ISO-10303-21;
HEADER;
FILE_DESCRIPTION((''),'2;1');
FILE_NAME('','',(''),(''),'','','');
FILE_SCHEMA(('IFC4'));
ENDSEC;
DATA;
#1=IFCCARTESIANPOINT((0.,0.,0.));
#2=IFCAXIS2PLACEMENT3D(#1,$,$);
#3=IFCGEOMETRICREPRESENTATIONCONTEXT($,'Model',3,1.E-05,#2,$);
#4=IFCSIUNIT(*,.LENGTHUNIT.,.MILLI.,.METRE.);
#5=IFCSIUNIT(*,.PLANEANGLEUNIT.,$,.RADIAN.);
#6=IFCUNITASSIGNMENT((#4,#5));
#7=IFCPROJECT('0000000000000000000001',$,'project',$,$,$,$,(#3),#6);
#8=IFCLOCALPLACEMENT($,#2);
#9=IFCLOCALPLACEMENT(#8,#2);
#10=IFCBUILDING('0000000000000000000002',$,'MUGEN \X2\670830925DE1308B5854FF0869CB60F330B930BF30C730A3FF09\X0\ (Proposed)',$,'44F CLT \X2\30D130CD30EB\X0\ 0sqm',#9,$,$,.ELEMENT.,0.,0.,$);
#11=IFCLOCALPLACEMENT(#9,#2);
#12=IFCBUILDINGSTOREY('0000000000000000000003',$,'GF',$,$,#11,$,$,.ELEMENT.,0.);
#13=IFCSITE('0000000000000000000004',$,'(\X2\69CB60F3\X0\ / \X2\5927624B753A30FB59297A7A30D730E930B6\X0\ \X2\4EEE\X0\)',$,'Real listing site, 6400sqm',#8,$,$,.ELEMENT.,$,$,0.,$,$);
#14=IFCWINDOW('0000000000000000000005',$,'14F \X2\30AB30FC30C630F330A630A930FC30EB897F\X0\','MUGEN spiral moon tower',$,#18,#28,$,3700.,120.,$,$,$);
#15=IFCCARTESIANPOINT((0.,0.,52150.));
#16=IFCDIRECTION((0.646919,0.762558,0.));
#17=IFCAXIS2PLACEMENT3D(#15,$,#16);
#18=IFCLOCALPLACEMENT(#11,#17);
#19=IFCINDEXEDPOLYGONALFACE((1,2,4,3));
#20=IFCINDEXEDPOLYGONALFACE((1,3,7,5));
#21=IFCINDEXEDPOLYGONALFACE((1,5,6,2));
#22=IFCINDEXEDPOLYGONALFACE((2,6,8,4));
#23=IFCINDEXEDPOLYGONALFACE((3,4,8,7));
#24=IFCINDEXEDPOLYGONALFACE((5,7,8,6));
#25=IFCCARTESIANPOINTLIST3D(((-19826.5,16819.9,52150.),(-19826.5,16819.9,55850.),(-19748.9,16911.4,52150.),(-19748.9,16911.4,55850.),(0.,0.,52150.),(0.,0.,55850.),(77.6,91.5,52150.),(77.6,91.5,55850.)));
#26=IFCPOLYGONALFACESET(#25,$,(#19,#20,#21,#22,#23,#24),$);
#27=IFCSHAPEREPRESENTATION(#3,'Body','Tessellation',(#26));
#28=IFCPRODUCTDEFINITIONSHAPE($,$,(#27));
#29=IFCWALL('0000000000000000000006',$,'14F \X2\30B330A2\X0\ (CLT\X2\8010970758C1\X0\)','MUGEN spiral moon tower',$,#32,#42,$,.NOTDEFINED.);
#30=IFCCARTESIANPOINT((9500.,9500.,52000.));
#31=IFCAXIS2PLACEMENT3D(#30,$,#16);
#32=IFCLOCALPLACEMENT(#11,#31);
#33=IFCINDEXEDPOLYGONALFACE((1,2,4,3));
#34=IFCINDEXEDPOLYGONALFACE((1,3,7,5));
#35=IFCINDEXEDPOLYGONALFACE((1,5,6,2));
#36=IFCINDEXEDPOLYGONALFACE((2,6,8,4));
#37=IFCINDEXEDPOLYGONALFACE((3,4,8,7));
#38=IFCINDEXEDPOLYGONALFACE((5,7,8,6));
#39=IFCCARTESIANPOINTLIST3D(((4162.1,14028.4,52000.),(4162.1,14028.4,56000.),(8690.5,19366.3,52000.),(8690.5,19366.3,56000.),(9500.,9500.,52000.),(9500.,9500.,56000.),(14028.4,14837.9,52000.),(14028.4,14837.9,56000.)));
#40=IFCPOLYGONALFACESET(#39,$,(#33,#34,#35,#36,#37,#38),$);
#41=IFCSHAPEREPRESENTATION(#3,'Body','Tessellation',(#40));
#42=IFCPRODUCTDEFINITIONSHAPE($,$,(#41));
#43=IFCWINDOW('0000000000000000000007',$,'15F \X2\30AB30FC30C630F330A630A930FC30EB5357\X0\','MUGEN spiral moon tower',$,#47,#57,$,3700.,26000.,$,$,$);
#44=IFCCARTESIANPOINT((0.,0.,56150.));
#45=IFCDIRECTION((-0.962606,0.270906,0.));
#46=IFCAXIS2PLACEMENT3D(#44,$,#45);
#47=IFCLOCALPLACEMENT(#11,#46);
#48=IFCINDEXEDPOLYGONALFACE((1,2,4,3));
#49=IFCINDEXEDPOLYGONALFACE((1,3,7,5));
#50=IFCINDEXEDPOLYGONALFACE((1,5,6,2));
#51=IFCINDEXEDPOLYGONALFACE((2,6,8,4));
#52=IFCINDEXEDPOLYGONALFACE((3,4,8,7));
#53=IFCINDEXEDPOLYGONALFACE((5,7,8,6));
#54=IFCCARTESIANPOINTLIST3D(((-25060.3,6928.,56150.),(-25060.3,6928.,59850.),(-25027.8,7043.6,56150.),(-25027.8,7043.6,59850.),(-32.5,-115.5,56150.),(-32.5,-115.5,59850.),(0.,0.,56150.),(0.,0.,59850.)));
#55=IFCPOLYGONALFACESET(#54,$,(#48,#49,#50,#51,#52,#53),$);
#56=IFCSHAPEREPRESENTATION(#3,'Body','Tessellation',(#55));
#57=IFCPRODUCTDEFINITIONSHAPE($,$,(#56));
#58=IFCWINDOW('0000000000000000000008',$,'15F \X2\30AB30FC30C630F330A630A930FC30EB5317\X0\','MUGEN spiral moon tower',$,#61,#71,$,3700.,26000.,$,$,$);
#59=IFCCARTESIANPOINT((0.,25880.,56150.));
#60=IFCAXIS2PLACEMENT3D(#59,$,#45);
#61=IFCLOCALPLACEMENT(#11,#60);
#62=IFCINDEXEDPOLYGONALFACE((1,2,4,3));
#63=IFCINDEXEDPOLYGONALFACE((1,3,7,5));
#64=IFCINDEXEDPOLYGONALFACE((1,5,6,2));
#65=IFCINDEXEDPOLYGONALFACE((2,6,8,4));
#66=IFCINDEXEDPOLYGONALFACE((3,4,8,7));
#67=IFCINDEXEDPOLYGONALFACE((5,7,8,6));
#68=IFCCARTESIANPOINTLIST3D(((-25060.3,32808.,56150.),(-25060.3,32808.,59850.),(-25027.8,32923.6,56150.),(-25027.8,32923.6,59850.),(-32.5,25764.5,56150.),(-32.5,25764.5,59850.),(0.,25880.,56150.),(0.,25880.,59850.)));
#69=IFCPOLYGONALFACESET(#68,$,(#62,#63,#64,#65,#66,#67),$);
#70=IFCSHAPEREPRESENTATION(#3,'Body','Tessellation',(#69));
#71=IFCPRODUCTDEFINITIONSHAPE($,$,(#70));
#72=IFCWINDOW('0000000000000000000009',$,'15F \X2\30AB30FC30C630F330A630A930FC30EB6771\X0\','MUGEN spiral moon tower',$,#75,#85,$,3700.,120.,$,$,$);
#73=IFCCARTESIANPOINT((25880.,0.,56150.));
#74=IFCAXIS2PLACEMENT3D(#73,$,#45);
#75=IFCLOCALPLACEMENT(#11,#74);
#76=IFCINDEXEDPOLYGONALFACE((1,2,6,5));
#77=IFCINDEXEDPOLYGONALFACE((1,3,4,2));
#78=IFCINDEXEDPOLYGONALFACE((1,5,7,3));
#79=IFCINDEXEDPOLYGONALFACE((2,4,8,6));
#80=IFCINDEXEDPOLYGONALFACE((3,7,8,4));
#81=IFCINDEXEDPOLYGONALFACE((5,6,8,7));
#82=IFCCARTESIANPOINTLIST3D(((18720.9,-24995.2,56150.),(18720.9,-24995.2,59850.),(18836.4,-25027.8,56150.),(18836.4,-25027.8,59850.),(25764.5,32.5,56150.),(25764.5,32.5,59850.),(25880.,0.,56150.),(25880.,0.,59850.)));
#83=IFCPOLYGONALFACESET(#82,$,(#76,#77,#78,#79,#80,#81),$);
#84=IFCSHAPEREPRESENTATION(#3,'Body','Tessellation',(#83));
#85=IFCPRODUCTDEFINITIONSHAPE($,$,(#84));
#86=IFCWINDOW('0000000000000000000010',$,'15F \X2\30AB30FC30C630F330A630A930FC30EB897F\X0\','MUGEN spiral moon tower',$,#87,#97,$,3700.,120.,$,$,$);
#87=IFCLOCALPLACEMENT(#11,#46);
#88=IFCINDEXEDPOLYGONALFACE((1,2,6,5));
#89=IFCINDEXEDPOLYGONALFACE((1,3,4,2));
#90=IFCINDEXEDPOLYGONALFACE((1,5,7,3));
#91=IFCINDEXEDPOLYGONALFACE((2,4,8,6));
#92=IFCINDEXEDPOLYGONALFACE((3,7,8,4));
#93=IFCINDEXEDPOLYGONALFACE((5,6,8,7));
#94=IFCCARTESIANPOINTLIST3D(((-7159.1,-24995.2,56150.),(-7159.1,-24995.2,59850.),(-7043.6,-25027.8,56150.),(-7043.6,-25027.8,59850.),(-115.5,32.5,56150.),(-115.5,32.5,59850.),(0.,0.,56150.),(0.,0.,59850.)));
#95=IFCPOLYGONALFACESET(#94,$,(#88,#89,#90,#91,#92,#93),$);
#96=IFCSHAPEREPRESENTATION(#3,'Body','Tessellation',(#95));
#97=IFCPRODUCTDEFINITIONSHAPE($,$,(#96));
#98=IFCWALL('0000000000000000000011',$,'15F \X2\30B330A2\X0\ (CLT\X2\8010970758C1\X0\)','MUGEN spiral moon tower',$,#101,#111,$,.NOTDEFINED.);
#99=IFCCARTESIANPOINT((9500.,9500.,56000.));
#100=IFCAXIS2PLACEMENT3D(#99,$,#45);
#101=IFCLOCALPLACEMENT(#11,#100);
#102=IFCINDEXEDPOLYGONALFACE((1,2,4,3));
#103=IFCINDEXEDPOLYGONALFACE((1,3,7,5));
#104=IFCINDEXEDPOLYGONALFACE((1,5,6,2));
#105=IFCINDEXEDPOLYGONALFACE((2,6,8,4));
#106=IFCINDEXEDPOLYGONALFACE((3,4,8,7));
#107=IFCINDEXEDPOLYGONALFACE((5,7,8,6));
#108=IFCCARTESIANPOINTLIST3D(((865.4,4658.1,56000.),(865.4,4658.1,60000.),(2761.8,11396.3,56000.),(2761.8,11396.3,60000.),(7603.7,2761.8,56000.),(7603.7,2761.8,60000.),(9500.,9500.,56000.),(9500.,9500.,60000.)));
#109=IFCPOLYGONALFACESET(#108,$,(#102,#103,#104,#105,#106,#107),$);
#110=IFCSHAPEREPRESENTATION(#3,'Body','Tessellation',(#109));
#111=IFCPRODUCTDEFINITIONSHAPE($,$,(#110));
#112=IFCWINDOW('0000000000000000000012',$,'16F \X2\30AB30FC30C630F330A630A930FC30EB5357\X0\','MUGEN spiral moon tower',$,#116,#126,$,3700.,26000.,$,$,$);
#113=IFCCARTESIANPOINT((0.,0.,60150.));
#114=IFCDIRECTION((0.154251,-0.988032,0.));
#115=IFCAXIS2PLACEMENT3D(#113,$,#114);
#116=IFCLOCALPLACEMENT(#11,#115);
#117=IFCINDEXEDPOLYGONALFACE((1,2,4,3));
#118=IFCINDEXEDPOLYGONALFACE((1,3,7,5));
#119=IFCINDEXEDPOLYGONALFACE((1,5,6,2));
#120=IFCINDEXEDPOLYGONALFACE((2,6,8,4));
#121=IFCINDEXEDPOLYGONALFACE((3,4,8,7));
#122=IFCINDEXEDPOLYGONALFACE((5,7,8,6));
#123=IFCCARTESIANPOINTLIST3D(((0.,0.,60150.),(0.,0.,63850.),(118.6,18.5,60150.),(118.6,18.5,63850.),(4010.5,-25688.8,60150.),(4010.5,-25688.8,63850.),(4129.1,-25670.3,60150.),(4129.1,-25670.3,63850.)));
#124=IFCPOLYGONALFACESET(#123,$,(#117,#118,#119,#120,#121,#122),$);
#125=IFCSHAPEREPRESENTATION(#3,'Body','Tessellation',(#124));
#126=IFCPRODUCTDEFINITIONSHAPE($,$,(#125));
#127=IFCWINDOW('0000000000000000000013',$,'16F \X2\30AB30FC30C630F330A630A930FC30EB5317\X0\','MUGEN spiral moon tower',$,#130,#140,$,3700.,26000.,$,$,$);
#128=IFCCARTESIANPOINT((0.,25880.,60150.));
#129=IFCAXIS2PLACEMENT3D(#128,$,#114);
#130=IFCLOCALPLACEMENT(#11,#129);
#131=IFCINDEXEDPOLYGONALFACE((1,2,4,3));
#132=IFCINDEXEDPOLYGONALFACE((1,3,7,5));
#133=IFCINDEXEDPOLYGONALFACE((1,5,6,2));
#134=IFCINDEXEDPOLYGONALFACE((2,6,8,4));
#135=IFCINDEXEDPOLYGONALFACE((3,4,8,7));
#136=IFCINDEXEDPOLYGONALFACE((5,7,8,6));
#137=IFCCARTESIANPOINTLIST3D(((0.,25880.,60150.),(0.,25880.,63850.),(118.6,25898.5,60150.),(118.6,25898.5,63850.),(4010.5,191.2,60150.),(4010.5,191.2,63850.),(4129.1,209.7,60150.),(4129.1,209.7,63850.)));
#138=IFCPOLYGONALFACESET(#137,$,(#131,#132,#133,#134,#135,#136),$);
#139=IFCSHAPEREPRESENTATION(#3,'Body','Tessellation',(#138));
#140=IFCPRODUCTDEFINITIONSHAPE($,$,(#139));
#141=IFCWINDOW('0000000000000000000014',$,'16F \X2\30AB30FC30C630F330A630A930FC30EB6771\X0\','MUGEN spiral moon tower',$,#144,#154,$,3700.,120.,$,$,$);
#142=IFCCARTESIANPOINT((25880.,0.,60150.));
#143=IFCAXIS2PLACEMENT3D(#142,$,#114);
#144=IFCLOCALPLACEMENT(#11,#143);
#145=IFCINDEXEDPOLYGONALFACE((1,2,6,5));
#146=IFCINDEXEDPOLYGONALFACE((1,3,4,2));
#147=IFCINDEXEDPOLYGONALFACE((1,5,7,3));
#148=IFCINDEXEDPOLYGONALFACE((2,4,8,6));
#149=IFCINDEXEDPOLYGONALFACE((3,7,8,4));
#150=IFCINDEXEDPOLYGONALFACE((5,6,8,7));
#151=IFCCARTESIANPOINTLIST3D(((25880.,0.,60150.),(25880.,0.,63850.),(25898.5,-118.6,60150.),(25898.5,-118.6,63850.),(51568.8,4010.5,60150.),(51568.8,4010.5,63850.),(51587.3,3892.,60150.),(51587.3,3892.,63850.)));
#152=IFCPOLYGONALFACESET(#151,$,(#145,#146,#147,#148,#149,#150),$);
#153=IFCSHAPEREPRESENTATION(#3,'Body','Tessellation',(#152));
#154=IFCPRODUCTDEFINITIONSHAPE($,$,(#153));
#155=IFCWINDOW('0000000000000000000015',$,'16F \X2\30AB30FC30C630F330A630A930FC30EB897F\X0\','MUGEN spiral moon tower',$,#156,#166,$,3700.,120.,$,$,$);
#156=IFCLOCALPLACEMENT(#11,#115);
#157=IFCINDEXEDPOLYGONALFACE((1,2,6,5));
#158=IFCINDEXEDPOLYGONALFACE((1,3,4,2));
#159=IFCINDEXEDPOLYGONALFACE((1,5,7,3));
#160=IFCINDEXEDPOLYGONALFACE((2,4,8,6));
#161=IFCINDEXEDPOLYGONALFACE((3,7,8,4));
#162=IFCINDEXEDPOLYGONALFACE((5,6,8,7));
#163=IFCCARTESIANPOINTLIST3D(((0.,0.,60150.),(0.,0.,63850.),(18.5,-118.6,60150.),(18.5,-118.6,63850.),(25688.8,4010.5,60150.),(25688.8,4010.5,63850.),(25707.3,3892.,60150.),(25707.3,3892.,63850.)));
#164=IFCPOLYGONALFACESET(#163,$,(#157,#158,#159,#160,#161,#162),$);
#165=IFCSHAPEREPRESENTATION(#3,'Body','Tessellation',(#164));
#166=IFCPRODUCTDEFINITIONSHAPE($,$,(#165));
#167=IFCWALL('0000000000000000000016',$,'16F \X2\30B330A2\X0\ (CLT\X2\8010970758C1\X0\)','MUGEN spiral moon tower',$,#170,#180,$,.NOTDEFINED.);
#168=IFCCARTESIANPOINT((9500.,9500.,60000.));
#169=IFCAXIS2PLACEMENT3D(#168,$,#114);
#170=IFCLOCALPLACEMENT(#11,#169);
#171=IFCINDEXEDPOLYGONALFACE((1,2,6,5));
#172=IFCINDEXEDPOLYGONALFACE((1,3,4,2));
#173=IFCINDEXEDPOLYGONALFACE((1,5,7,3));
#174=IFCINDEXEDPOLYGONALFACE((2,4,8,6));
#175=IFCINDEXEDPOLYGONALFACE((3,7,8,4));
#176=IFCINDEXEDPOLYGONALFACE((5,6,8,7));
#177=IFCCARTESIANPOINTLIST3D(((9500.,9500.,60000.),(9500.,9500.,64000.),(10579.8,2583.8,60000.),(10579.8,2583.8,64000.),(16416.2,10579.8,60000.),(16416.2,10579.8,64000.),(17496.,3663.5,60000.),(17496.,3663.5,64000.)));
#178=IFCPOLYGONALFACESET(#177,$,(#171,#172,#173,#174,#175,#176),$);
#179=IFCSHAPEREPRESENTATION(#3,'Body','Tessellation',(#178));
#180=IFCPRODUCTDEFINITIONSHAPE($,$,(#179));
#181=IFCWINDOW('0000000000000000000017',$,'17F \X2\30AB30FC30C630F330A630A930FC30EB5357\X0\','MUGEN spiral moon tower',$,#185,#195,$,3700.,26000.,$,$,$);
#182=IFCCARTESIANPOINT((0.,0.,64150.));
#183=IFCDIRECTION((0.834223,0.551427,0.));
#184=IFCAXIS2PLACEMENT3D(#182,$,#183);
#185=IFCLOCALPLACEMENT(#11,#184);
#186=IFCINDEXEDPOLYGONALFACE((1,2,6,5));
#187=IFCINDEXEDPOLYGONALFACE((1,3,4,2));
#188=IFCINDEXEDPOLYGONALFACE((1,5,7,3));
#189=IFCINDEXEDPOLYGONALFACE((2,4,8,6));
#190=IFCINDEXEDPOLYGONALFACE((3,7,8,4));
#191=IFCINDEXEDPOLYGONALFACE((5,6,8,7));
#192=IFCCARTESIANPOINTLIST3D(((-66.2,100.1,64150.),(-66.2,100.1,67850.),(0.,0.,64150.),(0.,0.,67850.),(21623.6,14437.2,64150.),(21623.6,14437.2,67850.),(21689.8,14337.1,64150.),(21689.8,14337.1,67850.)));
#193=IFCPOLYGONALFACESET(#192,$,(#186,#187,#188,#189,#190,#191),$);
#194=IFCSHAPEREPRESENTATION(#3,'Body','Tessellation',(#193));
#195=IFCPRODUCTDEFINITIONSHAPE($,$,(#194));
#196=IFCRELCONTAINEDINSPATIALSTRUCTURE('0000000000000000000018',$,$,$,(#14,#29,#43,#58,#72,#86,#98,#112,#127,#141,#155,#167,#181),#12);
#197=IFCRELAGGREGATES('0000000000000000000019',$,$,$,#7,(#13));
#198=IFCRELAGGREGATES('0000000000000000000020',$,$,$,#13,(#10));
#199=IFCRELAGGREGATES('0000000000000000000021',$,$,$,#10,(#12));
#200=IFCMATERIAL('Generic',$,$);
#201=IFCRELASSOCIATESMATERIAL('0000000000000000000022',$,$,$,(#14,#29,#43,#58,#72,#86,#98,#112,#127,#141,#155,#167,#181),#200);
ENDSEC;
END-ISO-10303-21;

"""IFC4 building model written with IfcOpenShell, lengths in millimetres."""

from ifc_helpers import new_model, si_unit, frame, frame_2d, origin, place, context, project, spatial, rectangle, extrude, material, element, save


model = new_model("IFC4")

# Units and contexts
model_context = context("Model", 3, precision=1e-05, world=origin())
ifc_project = project(units=[si_unit("LENGTHUNIT", "METRE", prefix="MILLI"), si_unit("PLANEANGLEUNIT", "RADIAN")], contexts=[model_context])

# Site, building, storey
site_placement = place(None, origin())
site = spatial("IfcSite", under=ifc_project, at=site_placement, Name="(構想 / 大手町・天空プラザ 仮)", ObjectType="Real listing site, 6400sqm", CompositionType="ELEMENT", RefElevation=0.0)
building_placement = place(site_placement, origin())
building = spatial("IfcBuilding", under=site, at=building_placement, Name="MUGEN 月を巡る塔（構想スタディ） (Proposed)", ObjectType="44F CLT パネル 0sqm", CompositionType="ELEMENT", ElevationOfRefHeight=0.0, ElevationOfTerrain=0.0)
storey_placement = place(building_placement, origin())
storey = spatial("IfcBuildingStorey", under=building, at=storey_placement, Name="GF", CompositionType="ELEMENT", Elevation=0.0)

# Shared definitions
ifc_material = material(Name="Generic")

# Window
window_1_placement = place(storey_placement, frame((0.0, 0.0, 52150.0), x_axis=(0.646919, 0.762558, 0.0)))
element("IfcWindow", 1, at=window_1_placement, inside=storey, material=ifc_material, Name="14F カーテンウォール西", Description="MUGEN spiral moon tower", OverallHeight=3700.0, OverallWidth=120.0, context=model_context, shape_type="SweptSolid", body=[
    extrude(rectangle(XDim=120.0, YDim=26000.0, at=frame_2d((60.0, 13000.0))), frame((0.0, 0.0, 52150.0), x_axis=(0.646919, 0.762558, 0.0)), (0.0, 0.0, 1.0), 3700.0),
])

# Wall
wall_1_placement = place(storey_placement, frame((9500.0, 9500.0, 52000.0), x_axis=(0.646919, 0.762558, 0.0)))
element("IfcWall", 2, at=wall_1_placement, inside=storey, material=ifc_material, Name="14F コア (CLT耐震壁)", Description="MUGEN spiral moon tower", PredefinedType="NOTDEFINED", context=model_context, shape_type="SweptSolid", body=[
    extrude(rectangle(XDim=7000.0, YDim=7000.0, at=frame_2d((3500.0, 3500.0))), frame((9500.0, 9500.0, 52000.0), x_axis=(0.646919, 0.762558, 0.0)), (0.0, 0.0, 1.0), 4000.0),
])

# Windows
window_2_placement = place(storey_placement, frame((0.0, 0.0, 56150.0), x_axis=(-0.962606, 0.270906, 0.0)))
element("IfcWindow", 3, at=window_2_placement, inside=storey, material=ifc_material, Name="15F カーテンウォール南", Description="MUGEN spiral moon tower", OverallHeight=3700.0, OverallWidth=26000.0, context=model_context, shape_type="SweptSolid", body=[
    extrude(rectangle(XDim=26000.0, YDim=120.0, at=frame_2d((13000.0, 60.0))), frame((0.0, 0.0, 56150.0), x_axis=(-0.962606, 0.270906, 0.0)), (0.0, 0.0, 1.0), 3700.0),
])
window_3_placement = place(storey_placement, frame((0.0, 25880.0, 56150.0), x_axis=(-0.962606, 0.270906, 0.0)))
element("IfcWindow", 4, at=window_3_placement, inside=storey, material=ifc_material, Name="15F カーテンウォール北", Description="MUGEN spiral moon tower", OverallHeight=3700.0, OverallWidth=26000.0, context=model_context, shape_type="SweptSolid", body=[
    extrude(rectangle(XDim=26000.0, YDim=120.0, at=frame_2d((13000.0, 60.0))), frame((0.0, 25880.0, 56150.0), x_axis=(-0.962606, 0.270906, 0.0)), (0.0, 0.0, 1.0), 3700.0),
])
window_4_placement = place(storey_placement, frame((25880.0, 0.0, 56150.0), x_axis=(-0.962606, 0.270906, 0.0)))
element("IfcWindow", 5, at=window_4_placement, inside=storey, material=ifc_material, Name="15F カーテンウォール東", Description="MUGEN spiral moon tower", OverallHeight=3700.0, OverallWidth=120.0, context=model_context, shape_type="SweptSolid", body=[
    extrude(rectangle(XDim=120.0, YDim=26000.0, at=frame_2d((60.0, 13000.0))), frame((25880.0, 0.0, 56150.0), x_axis=(-0.962606, 0.270906, 0.0)), (0.0, 0.0, 1.0), 3700.0),
])
window_5_placement = place(storey_placement, frame((0.0, 0.0, 56150.0), x_axis=(-0.962606, 0.270906, 0.0)))
element("IfcWindow", 6, at=window_5_placement, inside=storey, material=ifc_material, Name="15F カーテンウォール西", Description="MUGEN spiral moon tower", OverallHeight=3700.0, OverallWidth=120.0, context=model_context, shape_type="SweptSolid", body=[
    extrude(rectangle(XDim=120.0, YDim=26000.0, at=frame_2d((60.0, 13000.0))), frame((0.0, 0.0, 56150.0), x_axis=(-0.962606, 0.270906, 0.0)), (0.0, 0.0, 1.0), 3700.0),
])

# Wall
wall_2_placement = place(storey_placement, frame((9500.0, 9500.0, 56000.0), x_axis=(-0.962606, 0.270906, 0.0)))
element("IfcWall", 7, at=wall_2_placement, inside=storey, material=ifc_material, Name="15F コア (CLT耐震壁)", Description="MUGEN spiral moon tower", PredefinedType="NOTDEFINED", context=model_context, shape_type="SweptSolid", body=[
    extrude(rectangle(XDim=7000.0, YDim=7000.0, at=frame_2d((3500.0, 3500.0))), frame((9500.0, 9500.0, 56000.0), x_axis=(-0.962606, 0.270906, 0.0)), (0.0, 0.0, 1.0), 4000.0),
])

# Windows
window_6_placement = place(storey_placement, frame((0.0, 0.0, 60150.0), x_axis=(0.154251, -0.988032, 0.0)))
element("IfcWindow", 8, at=window_6_placement, inside=storey, material=ifc_material, Name="16F カーテンウォール南", Description="MUGEN spiral moon tower", OverallHeight=3700.0, OverallWidth=26000.0, context=model_context, shape_type="SweptSolid", body=[
    extrude(rectangle(XDim=26000.0, YDim=120.0, at=frame_2d((13000.0, 60.0))), frame((0.0, 0.0, 60150.0), x_axis=(0.154251, -0.988032, 0.0)), (0.0, 0.0, 1.0), 3700.0),
])
window_7_placement = place(storey_placement, frame((0.0, 25880.0, 60150.0), x_axis=(0.154251, -0.988032, 0.0)))
element("IfcWindow", 9, at=window_7_placement, inside=storey, material=ifc_material, Name="16F カーテンウォール北", Description="MUGEN spiral moon tower", OverallHeight=3700.0, OverallWidth=26000.0, context=model_context, shape_type="SweptSolid", body=[
    extrude(rectangle(XDim=26000.0, YDim=120.0, at=frame_2d((13000.0, 60.0))), frame((0.0, 25880.0, 60150.0), x_axis=(0.154251, -0.988032, 0.0)), (0.0, 0.0, 1.0), 3700.0),
])
window_8_placement = place(storey_placement, frame((25880.0, 0.0, 60150.0), x_axis=(0.154251, -0.988032, 0.0)))
element("IfcWindow", 10, at=window_8_placement, inside=storey, material=ifc_material, Name="16F カーテンウォール東", Description="MUGEN spiral moon tower", OverallHeight=3700.0, OverallWidth=120.0, context=model_context, shape_type="SweptSolid", body=[
    extrude(rectangle(XDim=120.0, YDim=26000.0, at=frame_2d((60.0, 13000.0))), frame((25880.0, 0.0, 60150.0), x_axis=(0.154251, -0.988032, 0.0)), (0.0, 0.0, 1.0), 3700.0),
])
window_9_placement = place(storey_placement, frame((0.0, 0.0, 60150.0), x_axis=(0.154251, -0.988032, 0.0)))
element("IfcWindow", 11, at=window_9_placement, inside=storey, material=ifc_material, Name="16F カーテンウォール西", Description="MUGEN spiral moon tower", OverallHeight=3700.0, OverallWidth=120.0, context=model_context, shape_type="SweptSolid", body=[
    extrude(rectangle(XDim=120.0, YDim=26000.0, at=frame_2d((60.0, 13000.0))), frame((0.0, 0.0, 60150.0), x_axis=(0.154251, -0.988032, 0.0)), (0.0, 0.0, 1.0), 3700.0),
])

# Wall
wall_3_placement = place(storey_placement, frame((9500.0, 9500.0, 60000.0), x_axis=(0.154251, -0.988032, 0.0)))
element("IfcWall", 12, at=wall_3_placement, inside=storey, material=ifc_material, Name="16F コア (CLT耐震壁)", Description="MUGEN spiral moon tower", PredefinedType="NOTDEFINED", context=model_context, shape_type="SweptSolid", body=[
    extrude(rectangle(XDim=7000.0, YDim=7000.0, at=frame_2d((3500.0, 3500.0))), frame((9500.0, 9500.0, 60000.0), x_axis=(0.154251, -0.988032, 0.0)), (0.0, 0.0, 1.0), 4000.0),
])

# Window
window_10_placement = place(storey_placement, frame((0.0, 0.0, 64150.0), x_axis=(0.834223, 0.551427, 0.0)))
element("IfcWindow", 13, at=window_10_placement, inside=storey, material=ifc_material, Name="17F カーテンウォール南", Description="MUGEN spiral moon tower", OverallHeight=3700.0, OverallWidth=26000.0, context=model_context, shape_type="SweptSolid", body=[
    extrude(rectangle(XDim=26000.0, YDim=120.0, at=frame_2d((13000.0, 60.0))), frame((0.0, 0.0, 64150.0), x_axis=(0.834223, 0.551427, 0.0)), (0.0, 0.0, 1.0), 3700.0),
])

save(model, "model.ifc")
